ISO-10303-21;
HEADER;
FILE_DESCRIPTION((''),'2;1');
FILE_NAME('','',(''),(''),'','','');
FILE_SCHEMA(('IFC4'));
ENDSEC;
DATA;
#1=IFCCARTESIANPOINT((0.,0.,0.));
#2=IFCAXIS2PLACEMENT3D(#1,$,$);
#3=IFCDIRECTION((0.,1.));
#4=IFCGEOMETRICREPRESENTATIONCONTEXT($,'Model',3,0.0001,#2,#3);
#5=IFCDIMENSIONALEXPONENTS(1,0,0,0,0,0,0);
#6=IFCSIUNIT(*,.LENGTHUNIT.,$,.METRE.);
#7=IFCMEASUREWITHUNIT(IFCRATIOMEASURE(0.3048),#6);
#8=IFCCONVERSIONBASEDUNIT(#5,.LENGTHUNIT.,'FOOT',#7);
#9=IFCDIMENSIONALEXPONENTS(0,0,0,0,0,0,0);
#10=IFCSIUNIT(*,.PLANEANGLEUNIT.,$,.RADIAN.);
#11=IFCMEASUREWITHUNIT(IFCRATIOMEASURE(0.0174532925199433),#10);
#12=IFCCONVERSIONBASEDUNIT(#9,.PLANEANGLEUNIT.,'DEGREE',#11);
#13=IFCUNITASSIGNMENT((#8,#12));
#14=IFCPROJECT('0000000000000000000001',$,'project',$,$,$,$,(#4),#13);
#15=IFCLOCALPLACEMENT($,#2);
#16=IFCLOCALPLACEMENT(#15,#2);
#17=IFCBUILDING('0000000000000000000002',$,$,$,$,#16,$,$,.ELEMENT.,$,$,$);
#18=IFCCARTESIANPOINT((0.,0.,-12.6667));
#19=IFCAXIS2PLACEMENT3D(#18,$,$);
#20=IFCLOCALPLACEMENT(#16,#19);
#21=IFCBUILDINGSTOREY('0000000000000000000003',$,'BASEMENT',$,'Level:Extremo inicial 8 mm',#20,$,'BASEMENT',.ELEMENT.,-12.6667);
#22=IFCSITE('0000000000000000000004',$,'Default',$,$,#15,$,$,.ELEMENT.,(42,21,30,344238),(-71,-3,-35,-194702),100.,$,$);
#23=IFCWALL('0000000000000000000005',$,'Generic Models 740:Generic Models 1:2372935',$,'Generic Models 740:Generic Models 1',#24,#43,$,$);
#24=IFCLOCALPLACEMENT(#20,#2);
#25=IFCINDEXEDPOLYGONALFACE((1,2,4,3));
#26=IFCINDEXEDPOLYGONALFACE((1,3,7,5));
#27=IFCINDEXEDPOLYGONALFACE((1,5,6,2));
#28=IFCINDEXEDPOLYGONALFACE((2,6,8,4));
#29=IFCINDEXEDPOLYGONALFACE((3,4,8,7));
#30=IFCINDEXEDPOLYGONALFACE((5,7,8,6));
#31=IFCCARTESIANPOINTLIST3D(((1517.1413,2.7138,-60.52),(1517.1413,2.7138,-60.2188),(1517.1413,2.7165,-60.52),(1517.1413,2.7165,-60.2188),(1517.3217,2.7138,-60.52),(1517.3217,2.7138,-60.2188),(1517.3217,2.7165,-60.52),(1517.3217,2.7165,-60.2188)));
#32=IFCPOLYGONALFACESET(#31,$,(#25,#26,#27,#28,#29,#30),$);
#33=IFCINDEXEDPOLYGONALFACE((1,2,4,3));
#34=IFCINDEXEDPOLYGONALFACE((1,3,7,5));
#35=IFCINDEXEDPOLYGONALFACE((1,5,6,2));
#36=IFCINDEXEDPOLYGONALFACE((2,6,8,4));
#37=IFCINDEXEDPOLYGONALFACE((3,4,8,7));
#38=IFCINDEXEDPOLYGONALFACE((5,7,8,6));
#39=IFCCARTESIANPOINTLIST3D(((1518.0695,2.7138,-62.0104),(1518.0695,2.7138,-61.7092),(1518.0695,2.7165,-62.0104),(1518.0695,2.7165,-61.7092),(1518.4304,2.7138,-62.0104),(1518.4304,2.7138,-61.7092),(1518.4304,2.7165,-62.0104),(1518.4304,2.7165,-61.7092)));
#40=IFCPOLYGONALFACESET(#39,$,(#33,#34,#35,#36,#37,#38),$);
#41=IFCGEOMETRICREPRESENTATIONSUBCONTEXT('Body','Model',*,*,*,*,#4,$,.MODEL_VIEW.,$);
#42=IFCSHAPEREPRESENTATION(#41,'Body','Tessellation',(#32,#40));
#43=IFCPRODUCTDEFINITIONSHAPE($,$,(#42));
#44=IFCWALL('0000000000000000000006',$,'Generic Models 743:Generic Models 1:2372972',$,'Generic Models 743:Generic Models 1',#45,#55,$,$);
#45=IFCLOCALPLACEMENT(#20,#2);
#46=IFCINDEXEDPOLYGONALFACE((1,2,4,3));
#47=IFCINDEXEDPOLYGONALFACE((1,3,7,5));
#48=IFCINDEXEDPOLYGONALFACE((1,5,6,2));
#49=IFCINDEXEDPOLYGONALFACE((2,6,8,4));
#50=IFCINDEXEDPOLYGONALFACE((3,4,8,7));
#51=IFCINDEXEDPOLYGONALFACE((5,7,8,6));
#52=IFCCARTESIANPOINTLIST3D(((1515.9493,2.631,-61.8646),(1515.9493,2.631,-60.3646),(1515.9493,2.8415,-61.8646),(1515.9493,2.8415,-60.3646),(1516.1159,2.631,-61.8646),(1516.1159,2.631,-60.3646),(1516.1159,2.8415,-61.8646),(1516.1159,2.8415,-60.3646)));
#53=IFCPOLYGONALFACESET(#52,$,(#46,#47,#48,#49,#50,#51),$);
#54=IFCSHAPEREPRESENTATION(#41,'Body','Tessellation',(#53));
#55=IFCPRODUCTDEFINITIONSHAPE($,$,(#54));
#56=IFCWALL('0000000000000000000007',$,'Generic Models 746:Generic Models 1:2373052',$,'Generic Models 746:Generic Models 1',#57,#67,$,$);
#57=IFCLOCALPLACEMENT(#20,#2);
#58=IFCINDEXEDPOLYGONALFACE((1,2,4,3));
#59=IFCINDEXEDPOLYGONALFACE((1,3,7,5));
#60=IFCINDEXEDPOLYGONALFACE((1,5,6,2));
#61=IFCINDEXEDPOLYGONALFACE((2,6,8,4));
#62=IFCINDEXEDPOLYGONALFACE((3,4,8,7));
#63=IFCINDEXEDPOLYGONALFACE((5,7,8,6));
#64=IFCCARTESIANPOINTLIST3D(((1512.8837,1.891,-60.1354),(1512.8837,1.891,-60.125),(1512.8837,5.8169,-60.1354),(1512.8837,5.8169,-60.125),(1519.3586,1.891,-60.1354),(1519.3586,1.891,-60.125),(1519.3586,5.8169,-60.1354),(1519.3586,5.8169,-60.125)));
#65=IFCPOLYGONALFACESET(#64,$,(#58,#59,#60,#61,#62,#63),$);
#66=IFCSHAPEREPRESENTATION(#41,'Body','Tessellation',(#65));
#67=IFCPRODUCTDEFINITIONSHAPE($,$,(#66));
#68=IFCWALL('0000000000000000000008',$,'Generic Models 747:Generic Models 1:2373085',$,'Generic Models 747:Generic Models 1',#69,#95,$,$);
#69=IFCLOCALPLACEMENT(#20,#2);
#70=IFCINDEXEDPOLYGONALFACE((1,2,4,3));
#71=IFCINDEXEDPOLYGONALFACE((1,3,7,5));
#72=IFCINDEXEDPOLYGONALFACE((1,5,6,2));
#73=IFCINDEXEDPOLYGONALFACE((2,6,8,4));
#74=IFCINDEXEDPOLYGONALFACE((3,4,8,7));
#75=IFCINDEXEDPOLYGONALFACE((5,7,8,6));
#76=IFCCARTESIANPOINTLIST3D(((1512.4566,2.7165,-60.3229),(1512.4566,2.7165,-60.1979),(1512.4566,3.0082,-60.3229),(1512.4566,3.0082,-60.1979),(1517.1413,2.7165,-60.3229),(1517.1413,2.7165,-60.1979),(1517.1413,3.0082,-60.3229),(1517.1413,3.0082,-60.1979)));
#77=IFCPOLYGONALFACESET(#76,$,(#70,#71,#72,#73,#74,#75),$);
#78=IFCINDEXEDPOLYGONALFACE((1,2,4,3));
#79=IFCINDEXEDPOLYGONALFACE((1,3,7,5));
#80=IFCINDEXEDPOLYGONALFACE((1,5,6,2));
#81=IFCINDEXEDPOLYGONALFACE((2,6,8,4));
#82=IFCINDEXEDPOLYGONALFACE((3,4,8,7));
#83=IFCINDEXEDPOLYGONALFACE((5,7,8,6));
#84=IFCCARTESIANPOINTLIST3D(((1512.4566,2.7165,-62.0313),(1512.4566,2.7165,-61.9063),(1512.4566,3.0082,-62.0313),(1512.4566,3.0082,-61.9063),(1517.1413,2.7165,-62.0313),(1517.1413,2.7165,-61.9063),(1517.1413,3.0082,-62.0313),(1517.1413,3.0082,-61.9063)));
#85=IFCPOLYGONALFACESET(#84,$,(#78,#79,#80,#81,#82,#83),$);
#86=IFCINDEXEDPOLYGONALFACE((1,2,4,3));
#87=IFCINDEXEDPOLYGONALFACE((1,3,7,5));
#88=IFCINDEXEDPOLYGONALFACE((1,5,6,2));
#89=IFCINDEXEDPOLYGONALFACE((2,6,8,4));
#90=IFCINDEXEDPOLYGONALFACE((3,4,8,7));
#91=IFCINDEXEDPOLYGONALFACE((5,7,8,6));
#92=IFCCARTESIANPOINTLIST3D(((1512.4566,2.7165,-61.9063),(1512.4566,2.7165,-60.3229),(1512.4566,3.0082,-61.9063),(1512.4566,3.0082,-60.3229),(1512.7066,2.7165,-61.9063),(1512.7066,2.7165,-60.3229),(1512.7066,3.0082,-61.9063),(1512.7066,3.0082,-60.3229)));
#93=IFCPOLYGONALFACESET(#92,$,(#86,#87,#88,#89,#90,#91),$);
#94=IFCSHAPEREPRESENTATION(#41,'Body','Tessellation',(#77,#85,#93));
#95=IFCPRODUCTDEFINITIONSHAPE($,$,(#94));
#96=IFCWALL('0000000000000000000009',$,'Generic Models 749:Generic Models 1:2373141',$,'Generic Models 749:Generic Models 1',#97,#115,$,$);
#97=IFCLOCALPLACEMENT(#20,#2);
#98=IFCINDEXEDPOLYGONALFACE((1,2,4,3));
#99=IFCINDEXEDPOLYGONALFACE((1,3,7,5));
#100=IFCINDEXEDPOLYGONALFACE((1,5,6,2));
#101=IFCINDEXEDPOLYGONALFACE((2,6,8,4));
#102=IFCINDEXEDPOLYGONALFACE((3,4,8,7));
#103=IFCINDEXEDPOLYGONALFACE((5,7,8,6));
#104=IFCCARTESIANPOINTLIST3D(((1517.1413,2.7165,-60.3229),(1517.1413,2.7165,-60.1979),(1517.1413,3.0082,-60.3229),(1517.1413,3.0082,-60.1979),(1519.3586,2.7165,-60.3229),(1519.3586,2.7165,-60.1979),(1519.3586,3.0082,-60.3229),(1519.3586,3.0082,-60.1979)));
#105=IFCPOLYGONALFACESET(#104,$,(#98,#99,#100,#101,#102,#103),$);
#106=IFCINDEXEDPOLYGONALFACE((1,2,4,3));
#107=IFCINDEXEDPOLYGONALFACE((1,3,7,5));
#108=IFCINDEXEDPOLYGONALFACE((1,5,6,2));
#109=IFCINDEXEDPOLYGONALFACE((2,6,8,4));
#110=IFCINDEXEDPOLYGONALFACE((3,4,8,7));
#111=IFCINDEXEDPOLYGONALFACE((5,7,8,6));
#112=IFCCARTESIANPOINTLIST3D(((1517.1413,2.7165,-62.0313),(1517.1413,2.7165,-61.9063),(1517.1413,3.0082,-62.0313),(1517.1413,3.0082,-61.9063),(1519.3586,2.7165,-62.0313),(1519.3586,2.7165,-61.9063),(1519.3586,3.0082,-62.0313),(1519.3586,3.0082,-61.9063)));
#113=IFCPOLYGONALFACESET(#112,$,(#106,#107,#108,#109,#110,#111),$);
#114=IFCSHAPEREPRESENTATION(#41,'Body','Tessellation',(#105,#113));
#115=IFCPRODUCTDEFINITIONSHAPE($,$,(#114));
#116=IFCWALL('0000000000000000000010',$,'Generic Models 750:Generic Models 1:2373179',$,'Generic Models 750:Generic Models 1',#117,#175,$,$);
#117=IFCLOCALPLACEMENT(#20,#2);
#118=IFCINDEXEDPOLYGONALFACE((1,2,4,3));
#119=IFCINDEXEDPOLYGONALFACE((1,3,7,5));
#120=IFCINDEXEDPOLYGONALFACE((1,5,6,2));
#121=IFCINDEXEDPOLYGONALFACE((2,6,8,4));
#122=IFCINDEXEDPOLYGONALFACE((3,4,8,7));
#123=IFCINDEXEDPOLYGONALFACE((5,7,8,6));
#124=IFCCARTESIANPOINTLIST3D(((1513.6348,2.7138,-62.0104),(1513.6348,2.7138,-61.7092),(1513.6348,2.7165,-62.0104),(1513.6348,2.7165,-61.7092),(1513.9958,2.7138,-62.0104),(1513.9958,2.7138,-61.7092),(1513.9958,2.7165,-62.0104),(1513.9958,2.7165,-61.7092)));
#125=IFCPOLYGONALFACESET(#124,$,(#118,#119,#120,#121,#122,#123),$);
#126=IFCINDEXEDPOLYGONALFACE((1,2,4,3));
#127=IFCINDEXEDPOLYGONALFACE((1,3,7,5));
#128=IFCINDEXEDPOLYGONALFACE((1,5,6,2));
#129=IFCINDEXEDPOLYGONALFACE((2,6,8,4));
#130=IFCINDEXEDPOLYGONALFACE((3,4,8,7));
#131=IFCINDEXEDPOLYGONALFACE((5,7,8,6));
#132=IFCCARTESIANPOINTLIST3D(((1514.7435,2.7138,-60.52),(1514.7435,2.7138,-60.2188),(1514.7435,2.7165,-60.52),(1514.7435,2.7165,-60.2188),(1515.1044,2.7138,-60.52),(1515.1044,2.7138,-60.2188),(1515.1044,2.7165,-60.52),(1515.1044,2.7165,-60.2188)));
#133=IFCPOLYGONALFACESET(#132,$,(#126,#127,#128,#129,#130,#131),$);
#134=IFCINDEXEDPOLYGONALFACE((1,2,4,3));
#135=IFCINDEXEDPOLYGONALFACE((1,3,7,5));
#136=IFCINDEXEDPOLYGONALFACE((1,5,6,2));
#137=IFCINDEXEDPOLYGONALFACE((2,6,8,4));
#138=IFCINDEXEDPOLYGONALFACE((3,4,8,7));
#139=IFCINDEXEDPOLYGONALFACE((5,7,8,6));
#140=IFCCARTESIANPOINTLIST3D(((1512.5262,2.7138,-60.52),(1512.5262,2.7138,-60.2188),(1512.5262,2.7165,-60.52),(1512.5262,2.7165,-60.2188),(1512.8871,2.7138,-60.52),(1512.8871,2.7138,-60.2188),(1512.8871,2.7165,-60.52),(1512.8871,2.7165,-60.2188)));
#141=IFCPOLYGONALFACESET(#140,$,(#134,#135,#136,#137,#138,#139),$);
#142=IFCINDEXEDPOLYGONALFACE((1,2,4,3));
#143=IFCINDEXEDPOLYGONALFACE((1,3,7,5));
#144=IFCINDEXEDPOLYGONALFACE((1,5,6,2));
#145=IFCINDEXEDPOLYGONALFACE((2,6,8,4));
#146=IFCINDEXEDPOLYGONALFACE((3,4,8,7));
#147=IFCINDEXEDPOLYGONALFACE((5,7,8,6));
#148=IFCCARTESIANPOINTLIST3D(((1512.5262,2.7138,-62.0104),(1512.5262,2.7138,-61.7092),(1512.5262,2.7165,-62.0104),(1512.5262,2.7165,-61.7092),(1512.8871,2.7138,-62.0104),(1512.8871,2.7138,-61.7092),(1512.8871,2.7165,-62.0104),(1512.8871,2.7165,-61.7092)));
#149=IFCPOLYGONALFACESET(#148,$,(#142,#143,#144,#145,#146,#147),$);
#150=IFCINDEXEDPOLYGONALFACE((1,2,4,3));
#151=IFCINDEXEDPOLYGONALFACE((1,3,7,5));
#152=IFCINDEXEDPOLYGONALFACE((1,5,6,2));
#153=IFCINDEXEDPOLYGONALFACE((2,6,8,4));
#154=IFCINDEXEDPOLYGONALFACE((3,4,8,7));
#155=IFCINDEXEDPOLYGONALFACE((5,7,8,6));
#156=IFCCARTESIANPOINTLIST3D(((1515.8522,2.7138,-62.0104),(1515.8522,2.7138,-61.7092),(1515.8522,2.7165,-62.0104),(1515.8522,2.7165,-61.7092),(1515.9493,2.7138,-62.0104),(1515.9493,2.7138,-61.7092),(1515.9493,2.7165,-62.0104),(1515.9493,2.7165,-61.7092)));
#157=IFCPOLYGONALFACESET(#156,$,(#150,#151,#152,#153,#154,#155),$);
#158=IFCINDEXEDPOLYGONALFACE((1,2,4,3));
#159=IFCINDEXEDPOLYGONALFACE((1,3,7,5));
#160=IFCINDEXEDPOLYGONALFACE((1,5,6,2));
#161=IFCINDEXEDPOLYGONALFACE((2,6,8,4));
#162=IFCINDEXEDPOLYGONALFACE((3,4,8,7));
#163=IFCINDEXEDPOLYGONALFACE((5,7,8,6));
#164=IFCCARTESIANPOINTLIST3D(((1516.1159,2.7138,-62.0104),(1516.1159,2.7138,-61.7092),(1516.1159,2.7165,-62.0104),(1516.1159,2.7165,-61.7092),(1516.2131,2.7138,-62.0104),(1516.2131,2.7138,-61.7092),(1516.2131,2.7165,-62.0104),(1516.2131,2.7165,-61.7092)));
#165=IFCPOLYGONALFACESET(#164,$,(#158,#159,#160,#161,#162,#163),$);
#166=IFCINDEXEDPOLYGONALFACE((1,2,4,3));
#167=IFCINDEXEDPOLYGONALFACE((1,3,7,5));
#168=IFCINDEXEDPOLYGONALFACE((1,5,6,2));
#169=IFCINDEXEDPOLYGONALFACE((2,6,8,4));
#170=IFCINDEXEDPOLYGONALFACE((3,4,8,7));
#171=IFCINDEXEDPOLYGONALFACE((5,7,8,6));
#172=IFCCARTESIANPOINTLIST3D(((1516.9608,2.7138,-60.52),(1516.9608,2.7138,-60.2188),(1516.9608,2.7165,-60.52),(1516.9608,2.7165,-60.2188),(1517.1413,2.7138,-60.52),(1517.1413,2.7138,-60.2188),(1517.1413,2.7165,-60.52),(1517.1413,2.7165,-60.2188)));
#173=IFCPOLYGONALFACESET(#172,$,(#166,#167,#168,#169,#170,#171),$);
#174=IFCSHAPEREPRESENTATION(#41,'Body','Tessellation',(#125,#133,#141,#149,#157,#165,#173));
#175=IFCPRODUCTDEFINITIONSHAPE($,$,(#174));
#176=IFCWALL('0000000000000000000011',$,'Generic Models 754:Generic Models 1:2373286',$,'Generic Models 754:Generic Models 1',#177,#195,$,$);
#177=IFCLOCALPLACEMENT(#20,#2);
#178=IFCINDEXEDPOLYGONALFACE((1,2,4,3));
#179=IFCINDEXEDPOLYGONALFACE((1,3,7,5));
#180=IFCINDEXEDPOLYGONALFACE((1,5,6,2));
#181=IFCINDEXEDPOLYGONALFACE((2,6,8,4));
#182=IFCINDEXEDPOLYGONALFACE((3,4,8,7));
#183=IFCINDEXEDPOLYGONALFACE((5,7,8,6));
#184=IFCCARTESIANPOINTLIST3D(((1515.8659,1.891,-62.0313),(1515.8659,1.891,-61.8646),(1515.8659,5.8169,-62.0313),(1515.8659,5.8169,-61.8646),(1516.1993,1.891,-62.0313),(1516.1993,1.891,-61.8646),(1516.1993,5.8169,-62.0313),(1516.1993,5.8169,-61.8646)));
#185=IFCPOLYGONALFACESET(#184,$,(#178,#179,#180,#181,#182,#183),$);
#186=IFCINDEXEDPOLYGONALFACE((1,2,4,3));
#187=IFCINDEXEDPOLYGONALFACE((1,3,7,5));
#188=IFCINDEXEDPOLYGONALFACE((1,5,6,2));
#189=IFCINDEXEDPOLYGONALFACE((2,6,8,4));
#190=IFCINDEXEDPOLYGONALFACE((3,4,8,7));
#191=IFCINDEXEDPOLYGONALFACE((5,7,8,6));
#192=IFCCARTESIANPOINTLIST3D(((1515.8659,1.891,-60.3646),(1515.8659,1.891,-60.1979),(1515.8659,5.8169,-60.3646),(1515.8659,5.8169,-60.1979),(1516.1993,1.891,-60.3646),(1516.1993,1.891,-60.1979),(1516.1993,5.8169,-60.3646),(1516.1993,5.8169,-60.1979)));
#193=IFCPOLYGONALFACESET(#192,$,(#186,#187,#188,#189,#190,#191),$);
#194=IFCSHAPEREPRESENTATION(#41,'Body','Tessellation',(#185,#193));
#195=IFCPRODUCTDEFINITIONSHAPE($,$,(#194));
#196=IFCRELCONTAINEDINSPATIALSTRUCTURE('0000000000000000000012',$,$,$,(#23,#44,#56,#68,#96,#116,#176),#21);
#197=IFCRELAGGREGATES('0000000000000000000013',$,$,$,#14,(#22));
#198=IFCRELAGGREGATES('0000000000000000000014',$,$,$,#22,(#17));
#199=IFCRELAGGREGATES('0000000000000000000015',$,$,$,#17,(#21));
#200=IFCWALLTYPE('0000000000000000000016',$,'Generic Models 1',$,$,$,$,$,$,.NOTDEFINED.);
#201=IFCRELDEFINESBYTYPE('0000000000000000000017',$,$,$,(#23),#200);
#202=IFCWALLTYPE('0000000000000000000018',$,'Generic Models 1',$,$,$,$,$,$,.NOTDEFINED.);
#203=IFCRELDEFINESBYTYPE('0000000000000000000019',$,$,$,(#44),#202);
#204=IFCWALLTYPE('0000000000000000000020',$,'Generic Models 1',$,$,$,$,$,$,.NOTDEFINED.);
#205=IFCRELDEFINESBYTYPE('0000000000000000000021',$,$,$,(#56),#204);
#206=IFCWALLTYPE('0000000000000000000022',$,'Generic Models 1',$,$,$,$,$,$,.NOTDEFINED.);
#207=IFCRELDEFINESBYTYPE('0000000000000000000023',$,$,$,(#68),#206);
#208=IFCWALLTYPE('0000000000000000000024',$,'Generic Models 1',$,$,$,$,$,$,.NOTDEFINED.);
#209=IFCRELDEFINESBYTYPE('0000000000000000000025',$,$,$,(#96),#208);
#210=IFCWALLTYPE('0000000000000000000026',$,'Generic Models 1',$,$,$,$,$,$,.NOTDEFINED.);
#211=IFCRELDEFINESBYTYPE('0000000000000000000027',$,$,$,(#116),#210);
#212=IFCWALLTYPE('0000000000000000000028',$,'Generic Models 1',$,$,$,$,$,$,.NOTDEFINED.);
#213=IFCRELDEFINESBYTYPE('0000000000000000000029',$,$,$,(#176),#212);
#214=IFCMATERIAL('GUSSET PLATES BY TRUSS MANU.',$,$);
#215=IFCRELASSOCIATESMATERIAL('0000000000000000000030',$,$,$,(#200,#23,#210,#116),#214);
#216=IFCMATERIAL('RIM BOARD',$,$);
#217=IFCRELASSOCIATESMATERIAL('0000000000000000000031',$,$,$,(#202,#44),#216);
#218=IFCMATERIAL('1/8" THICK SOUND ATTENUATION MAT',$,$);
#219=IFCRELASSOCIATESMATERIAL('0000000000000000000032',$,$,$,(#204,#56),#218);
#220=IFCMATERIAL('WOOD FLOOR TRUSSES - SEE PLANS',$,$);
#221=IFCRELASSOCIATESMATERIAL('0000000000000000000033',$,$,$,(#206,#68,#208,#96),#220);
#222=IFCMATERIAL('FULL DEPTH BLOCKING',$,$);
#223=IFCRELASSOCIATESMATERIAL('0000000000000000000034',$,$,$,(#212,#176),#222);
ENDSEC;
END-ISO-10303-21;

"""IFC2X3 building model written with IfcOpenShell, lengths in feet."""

from ifc_helpers import new_model, entity, si_unit, converted_unit, direction, frame, frame_2d, origin, origin_2d_with_axis, place, context, subcontext, project, spatial, rectangle, extrude, material, type_object, element, save


model = new_model("IFC2X3")

# Units and contexts
model_context = context("Model", 3, precision=0.0001, world=origin(), true_north=direction((0.0, 1.0)))
body_context = subcontext(model_context, "Body", "Model", "MODEL_VIEW")
ifc_project = project(units=[converted_unit("LENGTHUNIT", "FOOT", entity("IfcRatioMeasure", 0.3048), si_unit("LENGTHUNIT", "METRE"), dimensions=[1, 0, 0, 0, 0, 0, 0]), converted_unit("PLANEANGLEUNIT", "DEGREE", entity("IfcRatioMeasure", 0.0174532925199433), si_unit("PLANEANGLEUNIT", "RADIAN"), dimensions=[0, 0, 0, 0, 0, 0, 0])], contexts=[model_context])

# Site, building, storey
site_placement = place(None, origin())
site = spatial("IfcSite", under=ifc_project, at=site_placement, Name="Default", CompositionType="ELEMENT", RefLatitude=(42, 21, 30, 344238), RefLongitude=(-71, -3, -35, -194702), RefElevation=100.0)
building_placement = place(site_placement, origin())
building = spatial("IfcBuilding", under=site, at=building_placement, CompositionType="ELEMENT")
storey_placement = place(building_placement, frame((0.0, 0.0, -12.6667)))
storey = spatial("IfcBuildingStorey", under=building, at=storey_placement, Name="BASEMENT", ObjectType="Level:Extremo inicial 8 mm", LongName="BASEMENT", CompositionType="ELEMENT", Elevation=-12.6667)

# Walls
ifc_material_1 = material(Name="WOOD FLOOR TRUSSES - SEE PLANS")
ifc_material_2 = material(Name="1/8\" THICK SOUND ATTENUATION MAT")
ifc_material_3 = material(Name="GUSSET PLATES BY TRUSS MANU.")
wall_type_1 = type_object("IfcWallType", Name="Generic Models 1", PredefinedType="NOTDEFINED", material=ifc_material_3)
wall_1_placement = place(storey_placement, frame((1517.1413, 2.7138, -62.0104)))
element("IfcWall", 1, at=wall_1_placement, inside=storey, type_object=wall_type_1, material=ifc_material_3, Name="Generic Models 740:Generic Models 1:2372935", ObjectType="Generic Models 740:Generic Models 1", context=body_context, shape_type="SweptSolid", body=[
    extrude(rectangle(XDim=0.0028, YDim=0.1805, at=frame_2d((0.0, 0.0), x_axis=(1.0, 0.0))), frame((0.0902, 0.0014, 1.4904), z_axis=(0.0, 0.0, 1.0), x_axis=(0.0, 1.0, 0.0)), (0.0, 0.0, 1.0), 0.3013),
    extrude(rectangle(XDim=0.0028, YDim=0.3609, at=origin_2d_with_axis()), frame((1.1087, 0.0014, 0.0), z_axis=(0.0, 0.0, 1.0), x_axis=(0.0, 1.0, 0.0)), (0.0, 0.0, 1.0), 0.3013),
])
ifc_material_4 = material(Name="RIM BOARD")
wall_type_2 = type_object("IfcWallType", Name="Generic Models 1", PredefinedType="NOTDEFINED", material=ifc_material_4)
wall_2_placement = place(storey_placement, frame((1515.9493, 2.631, -61.8646), z_axis=(0.0, 0.0, 1.0), x_axis=(0.0, 1.0, 0.0)))
element("IfcWall", 2, at=wall_2_placement, inside=storey, type_object=wall_type_2, material=ifc_material_4, Name="Generic Models 743:Generic Models 1:2372972", ObjectType="Generic Models 743:Generic Models 1", context=body_context, shape_type="SweptSolid", body=[
    extrude(rectangle(XDim=0.2105, YDim=0.1667, at=origin_2d_with_axis()), frame((0.1053, -0.0833, 0.0)), (0.0, 0.0, 1.0), 1.5),
])
wall_type_3 = type_object("IfcWallType", Name="Generic Models 1", PredefinedType="NOTDEFINED", material=ifc_material_2)
wall_3_placement = place(storey_placement, frame((1512.8837, 1.891, -60.1354)))
element("IfcWall", 3, at=wall_3_placement, inside=storey, type_object=wall_type_3, material=ifc_material_2, Name="Generic Models 746:Generic Models 1:2373052", ObjectType="Generic Models 746:Generic Models 1", context=body_context, shape_type="SweptSolid", body=[
    extrude(rectangle(XDim=3.9258, YDim=6.4749, at=origin_2d_with_axis()), frame((3.2374, 1.9629, 0.0), z_axis=(0.0, 0.0, 1.0), x_axis=(0.0, 1.0, 0.0)), (0.0, 0.0, 1.0), 0.0104),
])
wall_type_4 = type_object("IfcWallType", Name="Generic Models 1", PredefinedType="NOTDEFINED", material=ifc_material_1)
wall_4_placement = place(storey_placement, frame((1512.4566, 2.7165, -62.0313)))
element("IfcWall", 4, at=wall_4_placement, inside=storey, type_object=wall_type_4, material=ifc_material_1, Name="Generic Models 747:Generic Models 1:2373085", ObjectType="Generic Models 747:Generic Models 1", context=body_context, shape_type="SweptSolid", body=[
    extrude(rectangle(XDim=0.2917, YDim=4.6846, at=origin_2d_with_axis()), frame((2.3423, 0.1458, 1.7083), z_axis=(0.0, 0.0, 1.0), x_axis=(0.0, 1.0, 0.0)), (0.0, 0.0, 1.0), 0.125),
    extrude(rectangle(XDim=0.2917, YDim=4.6846, at=frame_2d((0.0, 0.0), x_axis=(1.0, 0.0))), frame((2.3423, 0.1458, 0.0), z_axis=(0.0, 0.0, 1.0), x_axis=(0.0, 1.0, 0.0)), (0.0, 0.0, 1.0), 0.125),
    extrude(rectangle(XDim=0.2917, YDim=0.25, at=frame_2d((0.0, 0.0), x_axis=(1.0, 0.0))), frame((0.125, 0.1458, 0.125), z_axis=(0.0, 0.0, 1.0), x_axis=(0.0, 1.0, 0.0)), (0.0, 0.0, 1.0), 1.5833),
])
wall_type_5 = type_object("IfcWallType", Name="Generic Models 1", PredefinedType="NOTDEFINED", material=ifc_material_1)
wall_5_placement = place(storey_placement, frame((1517.1413, 2.7165, -62.0313)))
element("IfcWall", 5, at=wall_5_placement, inside=storey, type_object=wall_type_5, material=ifc_material_1, Name="Generic Models 749:Generic Models 1:2373141", ObjectType="Generic Models 749:Generic Models 1", context=body_context, shape_type="SweptSolid", body=[
    extrude(rectangle(XDim=0.2917, YDim=2.2173, at=frame_2d((0.0, 0.0), x_axis=(1.0, 0.0))), frame((1.1087, 0.1458, 1.7083), z_axis=(0.0, 0.0, 1.0), x_axis=(0.0, 1.0, 0.0)), (0.0, 0.0, 1.0), 0.125),
    extrude(rectangle(XDim=0.2917, YDim=2.2173, at=frame_2d((0.0, 0.0), x_axis=(1.0, 0.0))), frame((1.1087, 0.1458, 0.0), z_axis=(0.0, 0.0, 1.0), x_axis=(0.0, 1.0, 0.0)), (0.0, 0.0, 1.0), 0.125),
])
wall_type_6 = type_object("IfcWallType", Name="Generic Models 1", PredefinedType="NOTDEFINED", material=ifc_material_3)
wall_6_placement = place(storey_placement, frame((1512.5262, 2.7138, -62.0104)))
element("IfcWall", 6, at=wall_6_placement, inside=storey, type_object=wall_type_6, material=ifc_material_3, Name="Generic Models 750:Generic Models 1:2373179", ObjectType="Generic Models 750:Generic Models 1", context=body_context, shape_type="SweptSolid", body=[
    extrude(rectangle(XDim=0.0028, YDim=0.3609, at=origin_2d_with_axis()), frame((1.2891, 0.0014, 0.0), z_axis=(0.0, 0.0, 1.0), x_axis=(0.0, 1.0, 0.0)), (0.0, 0.0, 1.0), 0.3013),
    extrude(rectangle(XDim=0.0028, YDim=0.3609, at=origin_2d_with_axis()), frame((2.3978, 0.0014, 1.4904), z_axis=(0.0, 0.0, 1.0), x_axis=(0.0, 1.0, 0.0)), (0.0, 0.0, 1.0), 0.3013),
    extrude(rectangle(XDim=0.0028, YDim=0.3609, at=origin_2d_with_axis()), frame((0.1805, 0.0014, 1.4904), z_axis=(0.0, 0.0, 1.0), x_axis=(0.0, 1.0, 0.0)), (0.0, 0.0, 1.0), 0.3013),
    extrude(rectangle(XDim=0.0028, YDim=0.3609, at=frame_2d((0.0, 0.0), x_axis=(1.0, 0.0))), frame((0.1805, 0.0014, 0.0), z_axis=(0.0, 0.0, 1.0), x_axis=(0.0, 1.0, 0.0)), (0.0, 0.0, 1.0), 0.3013),
    extrude(rectangle(XDim=0.0028, YDim=0.0971, at=origin_2d_with_axis()), frame((3.3746, 0.0014, 0.0), z_axis=(0.0, 0.0, 1.0), x_axis=(0.0, 1.0, 0.0)), (0.0, 0.0, 1.0), 0.3013),
    extrude(rectangle(XDim=0.0028, YDim=0.0971, at=frame_2d((0.0, 0.0), x_axis=(1.0, 0.0))), frame((3.6384, 0.0014, 0.0), z_axis=(0.0, 0.0, 1.0), x_axis=(0.0, 1.0, 0.0)), (0.0, 0.0, 1.0), 0.3013),
    extrude(rectangle(XDim=0.0028, YDim=0.1805, at=frame_2d((0.0, 0.0), x_axis=(1.0, 0.0))), frame((4.5249, 0.0014, 1.4904), z_axis=(0.0, 0.0, 1.0), x_axis=(0.0, 1.0, 0.0)), (0.0, 0.0, 1.0), 0.3013),
])
ifc_material_5 = material(Name="FULL DEPTH BLOCKING")
wall_type_7 = type_object("IfcWallType", Name="Generic Models 1", PredefinedType="NOTDEFINED", material=ifc_material_5)
wall_7_placement = place(storey_placement, frame((1515.8659, 1.891, -62.0313), z_axis=(0.0, 0.0, 1.0), x_axis=(0.0, 1.0, 0.0)))
element("IfcWall", 7, at=wall_7_placement, inside=storey, type_object=wall_type_7, material=ifc_material_5, Name="Generic Models 754:Generic Models 1:2373286", ObjectType="Generic Models 754:Generic Models 1", context=body_context, shape_type="SweptSolid", body=[
    extrude(rectangle(XDim=3.9258, YDim=0.3333, at=frame_2d((0.0, 0.0), x_axis=(1.0, 0.0))), frame((1.9629, -0.1667, 0.0)), (0.0, 0.0, 1.0), 0.1667),
    extrude(rectangle(XDim=3.9258, YDim=0.3333, at=frame_2d((0.0, 0.0), x_axis=(1.0, 0.0))), frame((1.9629, -0.1667, 1.6667)), (0.0, 0.0, 1.0), 0.1667),
])

save(model, "model.ifc")
